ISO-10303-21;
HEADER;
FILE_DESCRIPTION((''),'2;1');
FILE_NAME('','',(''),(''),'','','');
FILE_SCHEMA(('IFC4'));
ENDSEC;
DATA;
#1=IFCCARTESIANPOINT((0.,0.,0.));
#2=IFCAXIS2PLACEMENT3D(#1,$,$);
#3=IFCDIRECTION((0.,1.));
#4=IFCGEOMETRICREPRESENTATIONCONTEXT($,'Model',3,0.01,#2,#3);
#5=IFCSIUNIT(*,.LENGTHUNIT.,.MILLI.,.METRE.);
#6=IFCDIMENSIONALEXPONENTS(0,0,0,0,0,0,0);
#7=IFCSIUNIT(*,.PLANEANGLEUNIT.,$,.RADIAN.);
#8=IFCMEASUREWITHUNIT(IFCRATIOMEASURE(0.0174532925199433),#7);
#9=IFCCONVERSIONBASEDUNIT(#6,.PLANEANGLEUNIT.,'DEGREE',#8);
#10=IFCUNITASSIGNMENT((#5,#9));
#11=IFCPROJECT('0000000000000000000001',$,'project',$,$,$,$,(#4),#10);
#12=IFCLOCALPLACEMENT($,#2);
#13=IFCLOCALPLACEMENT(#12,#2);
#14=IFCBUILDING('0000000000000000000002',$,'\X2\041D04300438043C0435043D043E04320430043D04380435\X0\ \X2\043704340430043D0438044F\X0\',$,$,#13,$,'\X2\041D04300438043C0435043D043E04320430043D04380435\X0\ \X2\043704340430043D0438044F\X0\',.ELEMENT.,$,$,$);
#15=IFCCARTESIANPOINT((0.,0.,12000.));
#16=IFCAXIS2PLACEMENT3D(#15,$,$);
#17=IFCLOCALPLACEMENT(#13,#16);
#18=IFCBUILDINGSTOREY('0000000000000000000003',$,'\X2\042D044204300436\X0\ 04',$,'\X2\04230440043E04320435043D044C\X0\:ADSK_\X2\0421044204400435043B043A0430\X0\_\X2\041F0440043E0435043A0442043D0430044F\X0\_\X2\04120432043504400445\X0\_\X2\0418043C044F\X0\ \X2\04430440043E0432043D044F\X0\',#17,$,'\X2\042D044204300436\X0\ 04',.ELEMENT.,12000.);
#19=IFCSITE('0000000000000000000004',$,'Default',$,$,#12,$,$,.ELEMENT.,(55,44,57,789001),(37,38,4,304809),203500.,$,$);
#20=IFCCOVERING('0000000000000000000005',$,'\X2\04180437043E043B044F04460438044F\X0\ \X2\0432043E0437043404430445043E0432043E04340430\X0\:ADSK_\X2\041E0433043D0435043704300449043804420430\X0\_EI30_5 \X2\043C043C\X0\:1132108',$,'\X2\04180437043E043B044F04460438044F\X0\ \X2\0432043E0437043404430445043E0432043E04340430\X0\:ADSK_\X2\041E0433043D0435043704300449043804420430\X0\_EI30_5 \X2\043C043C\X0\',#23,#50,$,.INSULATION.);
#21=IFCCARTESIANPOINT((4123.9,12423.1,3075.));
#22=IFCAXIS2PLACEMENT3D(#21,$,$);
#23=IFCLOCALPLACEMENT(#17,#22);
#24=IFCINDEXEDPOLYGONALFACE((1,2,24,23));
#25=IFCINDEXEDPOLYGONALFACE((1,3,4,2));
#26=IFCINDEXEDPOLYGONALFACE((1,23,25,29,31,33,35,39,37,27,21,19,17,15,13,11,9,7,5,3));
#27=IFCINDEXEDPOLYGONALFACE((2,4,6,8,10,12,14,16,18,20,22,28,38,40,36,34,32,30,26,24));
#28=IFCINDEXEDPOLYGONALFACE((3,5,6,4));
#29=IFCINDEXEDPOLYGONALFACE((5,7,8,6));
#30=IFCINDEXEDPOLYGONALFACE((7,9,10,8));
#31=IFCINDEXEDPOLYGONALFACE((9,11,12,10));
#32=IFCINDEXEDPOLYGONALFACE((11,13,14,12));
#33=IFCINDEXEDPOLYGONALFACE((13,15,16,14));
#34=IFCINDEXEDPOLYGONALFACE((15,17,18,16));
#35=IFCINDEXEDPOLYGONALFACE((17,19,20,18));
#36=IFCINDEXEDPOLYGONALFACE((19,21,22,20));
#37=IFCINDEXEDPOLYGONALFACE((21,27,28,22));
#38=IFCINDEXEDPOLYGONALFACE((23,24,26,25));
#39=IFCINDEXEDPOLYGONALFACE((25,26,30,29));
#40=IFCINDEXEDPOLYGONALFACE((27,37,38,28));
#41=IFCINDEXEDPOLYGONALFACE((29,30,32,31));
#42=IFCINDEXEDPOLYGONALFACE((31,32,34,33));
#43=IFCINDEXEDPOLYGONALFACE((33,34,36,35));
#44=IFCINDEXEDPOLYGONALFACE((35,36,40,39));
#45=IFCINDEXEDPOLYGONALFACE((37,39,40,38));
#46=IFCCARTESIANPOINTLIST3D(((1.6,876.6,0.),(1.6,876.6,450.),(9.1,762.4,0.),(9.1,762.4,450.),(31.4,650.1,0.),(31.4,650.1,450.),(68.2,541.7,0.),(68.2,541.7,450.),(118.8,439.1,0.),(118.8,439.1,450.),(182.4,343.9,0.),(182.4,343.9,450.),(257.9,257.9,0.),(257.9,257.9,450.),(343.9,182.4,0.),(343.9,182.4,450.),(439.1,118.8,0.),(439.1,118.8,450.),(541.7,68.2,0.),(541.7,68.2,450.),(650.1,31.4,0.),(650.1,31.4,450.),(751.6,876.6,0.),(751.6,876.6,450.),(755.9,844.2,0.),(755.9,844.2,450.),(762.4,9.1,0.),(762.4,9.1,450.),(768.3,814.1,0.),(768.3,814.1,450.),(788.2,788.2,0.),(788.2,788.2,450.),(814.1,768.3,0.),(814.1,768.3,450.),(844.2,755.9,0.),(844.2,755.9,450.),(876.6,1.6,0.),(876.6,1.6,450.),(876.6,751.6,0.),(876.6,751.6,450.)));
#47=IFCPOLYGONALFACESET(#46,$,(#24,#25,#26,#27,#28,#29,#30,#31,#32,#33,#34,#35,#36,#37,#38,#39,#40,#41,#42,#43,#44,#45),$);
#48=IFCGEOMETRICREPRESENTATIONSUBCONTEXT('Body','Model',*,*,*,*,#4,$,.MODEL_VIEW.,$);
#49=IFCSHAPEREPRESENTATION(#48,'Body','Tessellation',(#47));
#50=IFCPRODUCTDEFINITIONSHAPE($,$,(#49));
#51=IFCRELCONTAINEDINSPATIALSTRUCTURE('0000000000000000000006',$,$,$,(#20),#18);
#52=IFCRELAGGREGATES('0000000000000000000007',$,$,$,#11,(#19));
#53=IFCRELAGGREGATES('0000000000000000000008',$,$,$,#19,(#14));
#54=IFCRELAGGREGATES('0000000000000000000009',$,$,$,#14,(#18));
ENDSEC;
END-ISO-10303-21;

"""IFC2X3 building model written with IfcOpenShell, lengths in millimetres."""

from ifc_helpers import new_model, entity, si_unit, converted_unit, direction, frame, frame_2d, origin, place, context, subcontext, project, spatial, polyline, circle_curve, parameter, trimmed, segment, composite_curve, outline, extrude, element, save


model = new_model("IFC2X3")

# Units and contexts
model_context = context("Model", 3, precision=0.01, world=origin(), true_north=direction((0.0, 1.0)))
body_context = subcontext(model_context, "Body", "Model", "MODEL_VIEW")
ifc_project = project(units=[si_unit("LENGTHUNIT", "METRE", prefix="MILLI"), converted_unit("PLANEANGLEUNIT", "DEGREE", entity("IfcRatioMeasure", 0.0174532925199433), si_unit("PLANEANGLEUNIT", "RADIAN"), dimensions=[0, 0, 0, 0, 0, 0, 0])], contexts=[model_context])

# Site, building, storey
site_placement = place(None, frame((0.0, 0.0, 0.0)))
site = spatial("IfcSite", under=ifc_project, at=site_placement, Name="Default", CompositionType="ELEMENT", RefLatitude=(55, 44, 57, 789001), RefLongitude=(37, 38, 4, 304809), RefElevation=203500.0)
building_placement = place(site_placement, origin())
building = spatial("IfcBuilding", under=site, at=building_placement, Name="Наименование здания", LongName="Наименование здания", CompositionType="ELEMENT")
storey_placement = place(building_placement, frame((0.0, 0.0, 12000.0)))
storey = spatial("IfcBuildingStorey", under=building, at=storey_placement, Name="Этаж 04", ObjectType="Уровень:ADSK_Стрелка_Проектная_Вверх_Имя уровня", LongName="Этаж 04", CompositionType="ELEMENT", Elevation=12000.0)

# Covering
covering_1_placement = place(storey_placement, frame((4123.9, 12423.1, 3075.0)))
element("IfcCovering", 1, at=covering_1_placement, inside=storey, Name="Изоляция воздуховода:ADSK_Огнезащита_EI30_5 мм:1132108", ObjectType="Изоляция воздуховода:ADSK_Огнезащита_EI30_5 мм", PredefinedType="INSULATION", context=body_context, shape_type="SweptSolid", body=[
    extrude(outline(composite_curve([segment(polyline([(-250.0, 125.0), (-250.0, -625.0)]), True, "CONTINUOUS"), segment(trimmed(circle_curve(frame_2d((-250.0, 250.0), x_axis=(1.0, 0.0)), 875.0), [parameter(270.0)], [parameter(0.0)], True, "PARAMETER"), True, "CONTINUOUS"), segment(polyline([(625.0, 250.0), (-125.0, 250.0)]), True, "CONTINUOUS"), segment(trimmed(circle_curve(frame_2d((-250.0, 250.0), x_axis=(1.0, 0.0)), 125.0), [parameter(270.0)], [parameter(360.0)], True, "PARAMETER"), False, "CONTINUOUS")], self_intersect=False)), frame((626.6, 626.6, 0.0), z_axis=(0.0, 0.0, -1.0), x_axis=(-1.0, 0.0, 0.0)), (0.0, 0.0, -1.0), 450.0),
])

save(model, "model.ifc")
